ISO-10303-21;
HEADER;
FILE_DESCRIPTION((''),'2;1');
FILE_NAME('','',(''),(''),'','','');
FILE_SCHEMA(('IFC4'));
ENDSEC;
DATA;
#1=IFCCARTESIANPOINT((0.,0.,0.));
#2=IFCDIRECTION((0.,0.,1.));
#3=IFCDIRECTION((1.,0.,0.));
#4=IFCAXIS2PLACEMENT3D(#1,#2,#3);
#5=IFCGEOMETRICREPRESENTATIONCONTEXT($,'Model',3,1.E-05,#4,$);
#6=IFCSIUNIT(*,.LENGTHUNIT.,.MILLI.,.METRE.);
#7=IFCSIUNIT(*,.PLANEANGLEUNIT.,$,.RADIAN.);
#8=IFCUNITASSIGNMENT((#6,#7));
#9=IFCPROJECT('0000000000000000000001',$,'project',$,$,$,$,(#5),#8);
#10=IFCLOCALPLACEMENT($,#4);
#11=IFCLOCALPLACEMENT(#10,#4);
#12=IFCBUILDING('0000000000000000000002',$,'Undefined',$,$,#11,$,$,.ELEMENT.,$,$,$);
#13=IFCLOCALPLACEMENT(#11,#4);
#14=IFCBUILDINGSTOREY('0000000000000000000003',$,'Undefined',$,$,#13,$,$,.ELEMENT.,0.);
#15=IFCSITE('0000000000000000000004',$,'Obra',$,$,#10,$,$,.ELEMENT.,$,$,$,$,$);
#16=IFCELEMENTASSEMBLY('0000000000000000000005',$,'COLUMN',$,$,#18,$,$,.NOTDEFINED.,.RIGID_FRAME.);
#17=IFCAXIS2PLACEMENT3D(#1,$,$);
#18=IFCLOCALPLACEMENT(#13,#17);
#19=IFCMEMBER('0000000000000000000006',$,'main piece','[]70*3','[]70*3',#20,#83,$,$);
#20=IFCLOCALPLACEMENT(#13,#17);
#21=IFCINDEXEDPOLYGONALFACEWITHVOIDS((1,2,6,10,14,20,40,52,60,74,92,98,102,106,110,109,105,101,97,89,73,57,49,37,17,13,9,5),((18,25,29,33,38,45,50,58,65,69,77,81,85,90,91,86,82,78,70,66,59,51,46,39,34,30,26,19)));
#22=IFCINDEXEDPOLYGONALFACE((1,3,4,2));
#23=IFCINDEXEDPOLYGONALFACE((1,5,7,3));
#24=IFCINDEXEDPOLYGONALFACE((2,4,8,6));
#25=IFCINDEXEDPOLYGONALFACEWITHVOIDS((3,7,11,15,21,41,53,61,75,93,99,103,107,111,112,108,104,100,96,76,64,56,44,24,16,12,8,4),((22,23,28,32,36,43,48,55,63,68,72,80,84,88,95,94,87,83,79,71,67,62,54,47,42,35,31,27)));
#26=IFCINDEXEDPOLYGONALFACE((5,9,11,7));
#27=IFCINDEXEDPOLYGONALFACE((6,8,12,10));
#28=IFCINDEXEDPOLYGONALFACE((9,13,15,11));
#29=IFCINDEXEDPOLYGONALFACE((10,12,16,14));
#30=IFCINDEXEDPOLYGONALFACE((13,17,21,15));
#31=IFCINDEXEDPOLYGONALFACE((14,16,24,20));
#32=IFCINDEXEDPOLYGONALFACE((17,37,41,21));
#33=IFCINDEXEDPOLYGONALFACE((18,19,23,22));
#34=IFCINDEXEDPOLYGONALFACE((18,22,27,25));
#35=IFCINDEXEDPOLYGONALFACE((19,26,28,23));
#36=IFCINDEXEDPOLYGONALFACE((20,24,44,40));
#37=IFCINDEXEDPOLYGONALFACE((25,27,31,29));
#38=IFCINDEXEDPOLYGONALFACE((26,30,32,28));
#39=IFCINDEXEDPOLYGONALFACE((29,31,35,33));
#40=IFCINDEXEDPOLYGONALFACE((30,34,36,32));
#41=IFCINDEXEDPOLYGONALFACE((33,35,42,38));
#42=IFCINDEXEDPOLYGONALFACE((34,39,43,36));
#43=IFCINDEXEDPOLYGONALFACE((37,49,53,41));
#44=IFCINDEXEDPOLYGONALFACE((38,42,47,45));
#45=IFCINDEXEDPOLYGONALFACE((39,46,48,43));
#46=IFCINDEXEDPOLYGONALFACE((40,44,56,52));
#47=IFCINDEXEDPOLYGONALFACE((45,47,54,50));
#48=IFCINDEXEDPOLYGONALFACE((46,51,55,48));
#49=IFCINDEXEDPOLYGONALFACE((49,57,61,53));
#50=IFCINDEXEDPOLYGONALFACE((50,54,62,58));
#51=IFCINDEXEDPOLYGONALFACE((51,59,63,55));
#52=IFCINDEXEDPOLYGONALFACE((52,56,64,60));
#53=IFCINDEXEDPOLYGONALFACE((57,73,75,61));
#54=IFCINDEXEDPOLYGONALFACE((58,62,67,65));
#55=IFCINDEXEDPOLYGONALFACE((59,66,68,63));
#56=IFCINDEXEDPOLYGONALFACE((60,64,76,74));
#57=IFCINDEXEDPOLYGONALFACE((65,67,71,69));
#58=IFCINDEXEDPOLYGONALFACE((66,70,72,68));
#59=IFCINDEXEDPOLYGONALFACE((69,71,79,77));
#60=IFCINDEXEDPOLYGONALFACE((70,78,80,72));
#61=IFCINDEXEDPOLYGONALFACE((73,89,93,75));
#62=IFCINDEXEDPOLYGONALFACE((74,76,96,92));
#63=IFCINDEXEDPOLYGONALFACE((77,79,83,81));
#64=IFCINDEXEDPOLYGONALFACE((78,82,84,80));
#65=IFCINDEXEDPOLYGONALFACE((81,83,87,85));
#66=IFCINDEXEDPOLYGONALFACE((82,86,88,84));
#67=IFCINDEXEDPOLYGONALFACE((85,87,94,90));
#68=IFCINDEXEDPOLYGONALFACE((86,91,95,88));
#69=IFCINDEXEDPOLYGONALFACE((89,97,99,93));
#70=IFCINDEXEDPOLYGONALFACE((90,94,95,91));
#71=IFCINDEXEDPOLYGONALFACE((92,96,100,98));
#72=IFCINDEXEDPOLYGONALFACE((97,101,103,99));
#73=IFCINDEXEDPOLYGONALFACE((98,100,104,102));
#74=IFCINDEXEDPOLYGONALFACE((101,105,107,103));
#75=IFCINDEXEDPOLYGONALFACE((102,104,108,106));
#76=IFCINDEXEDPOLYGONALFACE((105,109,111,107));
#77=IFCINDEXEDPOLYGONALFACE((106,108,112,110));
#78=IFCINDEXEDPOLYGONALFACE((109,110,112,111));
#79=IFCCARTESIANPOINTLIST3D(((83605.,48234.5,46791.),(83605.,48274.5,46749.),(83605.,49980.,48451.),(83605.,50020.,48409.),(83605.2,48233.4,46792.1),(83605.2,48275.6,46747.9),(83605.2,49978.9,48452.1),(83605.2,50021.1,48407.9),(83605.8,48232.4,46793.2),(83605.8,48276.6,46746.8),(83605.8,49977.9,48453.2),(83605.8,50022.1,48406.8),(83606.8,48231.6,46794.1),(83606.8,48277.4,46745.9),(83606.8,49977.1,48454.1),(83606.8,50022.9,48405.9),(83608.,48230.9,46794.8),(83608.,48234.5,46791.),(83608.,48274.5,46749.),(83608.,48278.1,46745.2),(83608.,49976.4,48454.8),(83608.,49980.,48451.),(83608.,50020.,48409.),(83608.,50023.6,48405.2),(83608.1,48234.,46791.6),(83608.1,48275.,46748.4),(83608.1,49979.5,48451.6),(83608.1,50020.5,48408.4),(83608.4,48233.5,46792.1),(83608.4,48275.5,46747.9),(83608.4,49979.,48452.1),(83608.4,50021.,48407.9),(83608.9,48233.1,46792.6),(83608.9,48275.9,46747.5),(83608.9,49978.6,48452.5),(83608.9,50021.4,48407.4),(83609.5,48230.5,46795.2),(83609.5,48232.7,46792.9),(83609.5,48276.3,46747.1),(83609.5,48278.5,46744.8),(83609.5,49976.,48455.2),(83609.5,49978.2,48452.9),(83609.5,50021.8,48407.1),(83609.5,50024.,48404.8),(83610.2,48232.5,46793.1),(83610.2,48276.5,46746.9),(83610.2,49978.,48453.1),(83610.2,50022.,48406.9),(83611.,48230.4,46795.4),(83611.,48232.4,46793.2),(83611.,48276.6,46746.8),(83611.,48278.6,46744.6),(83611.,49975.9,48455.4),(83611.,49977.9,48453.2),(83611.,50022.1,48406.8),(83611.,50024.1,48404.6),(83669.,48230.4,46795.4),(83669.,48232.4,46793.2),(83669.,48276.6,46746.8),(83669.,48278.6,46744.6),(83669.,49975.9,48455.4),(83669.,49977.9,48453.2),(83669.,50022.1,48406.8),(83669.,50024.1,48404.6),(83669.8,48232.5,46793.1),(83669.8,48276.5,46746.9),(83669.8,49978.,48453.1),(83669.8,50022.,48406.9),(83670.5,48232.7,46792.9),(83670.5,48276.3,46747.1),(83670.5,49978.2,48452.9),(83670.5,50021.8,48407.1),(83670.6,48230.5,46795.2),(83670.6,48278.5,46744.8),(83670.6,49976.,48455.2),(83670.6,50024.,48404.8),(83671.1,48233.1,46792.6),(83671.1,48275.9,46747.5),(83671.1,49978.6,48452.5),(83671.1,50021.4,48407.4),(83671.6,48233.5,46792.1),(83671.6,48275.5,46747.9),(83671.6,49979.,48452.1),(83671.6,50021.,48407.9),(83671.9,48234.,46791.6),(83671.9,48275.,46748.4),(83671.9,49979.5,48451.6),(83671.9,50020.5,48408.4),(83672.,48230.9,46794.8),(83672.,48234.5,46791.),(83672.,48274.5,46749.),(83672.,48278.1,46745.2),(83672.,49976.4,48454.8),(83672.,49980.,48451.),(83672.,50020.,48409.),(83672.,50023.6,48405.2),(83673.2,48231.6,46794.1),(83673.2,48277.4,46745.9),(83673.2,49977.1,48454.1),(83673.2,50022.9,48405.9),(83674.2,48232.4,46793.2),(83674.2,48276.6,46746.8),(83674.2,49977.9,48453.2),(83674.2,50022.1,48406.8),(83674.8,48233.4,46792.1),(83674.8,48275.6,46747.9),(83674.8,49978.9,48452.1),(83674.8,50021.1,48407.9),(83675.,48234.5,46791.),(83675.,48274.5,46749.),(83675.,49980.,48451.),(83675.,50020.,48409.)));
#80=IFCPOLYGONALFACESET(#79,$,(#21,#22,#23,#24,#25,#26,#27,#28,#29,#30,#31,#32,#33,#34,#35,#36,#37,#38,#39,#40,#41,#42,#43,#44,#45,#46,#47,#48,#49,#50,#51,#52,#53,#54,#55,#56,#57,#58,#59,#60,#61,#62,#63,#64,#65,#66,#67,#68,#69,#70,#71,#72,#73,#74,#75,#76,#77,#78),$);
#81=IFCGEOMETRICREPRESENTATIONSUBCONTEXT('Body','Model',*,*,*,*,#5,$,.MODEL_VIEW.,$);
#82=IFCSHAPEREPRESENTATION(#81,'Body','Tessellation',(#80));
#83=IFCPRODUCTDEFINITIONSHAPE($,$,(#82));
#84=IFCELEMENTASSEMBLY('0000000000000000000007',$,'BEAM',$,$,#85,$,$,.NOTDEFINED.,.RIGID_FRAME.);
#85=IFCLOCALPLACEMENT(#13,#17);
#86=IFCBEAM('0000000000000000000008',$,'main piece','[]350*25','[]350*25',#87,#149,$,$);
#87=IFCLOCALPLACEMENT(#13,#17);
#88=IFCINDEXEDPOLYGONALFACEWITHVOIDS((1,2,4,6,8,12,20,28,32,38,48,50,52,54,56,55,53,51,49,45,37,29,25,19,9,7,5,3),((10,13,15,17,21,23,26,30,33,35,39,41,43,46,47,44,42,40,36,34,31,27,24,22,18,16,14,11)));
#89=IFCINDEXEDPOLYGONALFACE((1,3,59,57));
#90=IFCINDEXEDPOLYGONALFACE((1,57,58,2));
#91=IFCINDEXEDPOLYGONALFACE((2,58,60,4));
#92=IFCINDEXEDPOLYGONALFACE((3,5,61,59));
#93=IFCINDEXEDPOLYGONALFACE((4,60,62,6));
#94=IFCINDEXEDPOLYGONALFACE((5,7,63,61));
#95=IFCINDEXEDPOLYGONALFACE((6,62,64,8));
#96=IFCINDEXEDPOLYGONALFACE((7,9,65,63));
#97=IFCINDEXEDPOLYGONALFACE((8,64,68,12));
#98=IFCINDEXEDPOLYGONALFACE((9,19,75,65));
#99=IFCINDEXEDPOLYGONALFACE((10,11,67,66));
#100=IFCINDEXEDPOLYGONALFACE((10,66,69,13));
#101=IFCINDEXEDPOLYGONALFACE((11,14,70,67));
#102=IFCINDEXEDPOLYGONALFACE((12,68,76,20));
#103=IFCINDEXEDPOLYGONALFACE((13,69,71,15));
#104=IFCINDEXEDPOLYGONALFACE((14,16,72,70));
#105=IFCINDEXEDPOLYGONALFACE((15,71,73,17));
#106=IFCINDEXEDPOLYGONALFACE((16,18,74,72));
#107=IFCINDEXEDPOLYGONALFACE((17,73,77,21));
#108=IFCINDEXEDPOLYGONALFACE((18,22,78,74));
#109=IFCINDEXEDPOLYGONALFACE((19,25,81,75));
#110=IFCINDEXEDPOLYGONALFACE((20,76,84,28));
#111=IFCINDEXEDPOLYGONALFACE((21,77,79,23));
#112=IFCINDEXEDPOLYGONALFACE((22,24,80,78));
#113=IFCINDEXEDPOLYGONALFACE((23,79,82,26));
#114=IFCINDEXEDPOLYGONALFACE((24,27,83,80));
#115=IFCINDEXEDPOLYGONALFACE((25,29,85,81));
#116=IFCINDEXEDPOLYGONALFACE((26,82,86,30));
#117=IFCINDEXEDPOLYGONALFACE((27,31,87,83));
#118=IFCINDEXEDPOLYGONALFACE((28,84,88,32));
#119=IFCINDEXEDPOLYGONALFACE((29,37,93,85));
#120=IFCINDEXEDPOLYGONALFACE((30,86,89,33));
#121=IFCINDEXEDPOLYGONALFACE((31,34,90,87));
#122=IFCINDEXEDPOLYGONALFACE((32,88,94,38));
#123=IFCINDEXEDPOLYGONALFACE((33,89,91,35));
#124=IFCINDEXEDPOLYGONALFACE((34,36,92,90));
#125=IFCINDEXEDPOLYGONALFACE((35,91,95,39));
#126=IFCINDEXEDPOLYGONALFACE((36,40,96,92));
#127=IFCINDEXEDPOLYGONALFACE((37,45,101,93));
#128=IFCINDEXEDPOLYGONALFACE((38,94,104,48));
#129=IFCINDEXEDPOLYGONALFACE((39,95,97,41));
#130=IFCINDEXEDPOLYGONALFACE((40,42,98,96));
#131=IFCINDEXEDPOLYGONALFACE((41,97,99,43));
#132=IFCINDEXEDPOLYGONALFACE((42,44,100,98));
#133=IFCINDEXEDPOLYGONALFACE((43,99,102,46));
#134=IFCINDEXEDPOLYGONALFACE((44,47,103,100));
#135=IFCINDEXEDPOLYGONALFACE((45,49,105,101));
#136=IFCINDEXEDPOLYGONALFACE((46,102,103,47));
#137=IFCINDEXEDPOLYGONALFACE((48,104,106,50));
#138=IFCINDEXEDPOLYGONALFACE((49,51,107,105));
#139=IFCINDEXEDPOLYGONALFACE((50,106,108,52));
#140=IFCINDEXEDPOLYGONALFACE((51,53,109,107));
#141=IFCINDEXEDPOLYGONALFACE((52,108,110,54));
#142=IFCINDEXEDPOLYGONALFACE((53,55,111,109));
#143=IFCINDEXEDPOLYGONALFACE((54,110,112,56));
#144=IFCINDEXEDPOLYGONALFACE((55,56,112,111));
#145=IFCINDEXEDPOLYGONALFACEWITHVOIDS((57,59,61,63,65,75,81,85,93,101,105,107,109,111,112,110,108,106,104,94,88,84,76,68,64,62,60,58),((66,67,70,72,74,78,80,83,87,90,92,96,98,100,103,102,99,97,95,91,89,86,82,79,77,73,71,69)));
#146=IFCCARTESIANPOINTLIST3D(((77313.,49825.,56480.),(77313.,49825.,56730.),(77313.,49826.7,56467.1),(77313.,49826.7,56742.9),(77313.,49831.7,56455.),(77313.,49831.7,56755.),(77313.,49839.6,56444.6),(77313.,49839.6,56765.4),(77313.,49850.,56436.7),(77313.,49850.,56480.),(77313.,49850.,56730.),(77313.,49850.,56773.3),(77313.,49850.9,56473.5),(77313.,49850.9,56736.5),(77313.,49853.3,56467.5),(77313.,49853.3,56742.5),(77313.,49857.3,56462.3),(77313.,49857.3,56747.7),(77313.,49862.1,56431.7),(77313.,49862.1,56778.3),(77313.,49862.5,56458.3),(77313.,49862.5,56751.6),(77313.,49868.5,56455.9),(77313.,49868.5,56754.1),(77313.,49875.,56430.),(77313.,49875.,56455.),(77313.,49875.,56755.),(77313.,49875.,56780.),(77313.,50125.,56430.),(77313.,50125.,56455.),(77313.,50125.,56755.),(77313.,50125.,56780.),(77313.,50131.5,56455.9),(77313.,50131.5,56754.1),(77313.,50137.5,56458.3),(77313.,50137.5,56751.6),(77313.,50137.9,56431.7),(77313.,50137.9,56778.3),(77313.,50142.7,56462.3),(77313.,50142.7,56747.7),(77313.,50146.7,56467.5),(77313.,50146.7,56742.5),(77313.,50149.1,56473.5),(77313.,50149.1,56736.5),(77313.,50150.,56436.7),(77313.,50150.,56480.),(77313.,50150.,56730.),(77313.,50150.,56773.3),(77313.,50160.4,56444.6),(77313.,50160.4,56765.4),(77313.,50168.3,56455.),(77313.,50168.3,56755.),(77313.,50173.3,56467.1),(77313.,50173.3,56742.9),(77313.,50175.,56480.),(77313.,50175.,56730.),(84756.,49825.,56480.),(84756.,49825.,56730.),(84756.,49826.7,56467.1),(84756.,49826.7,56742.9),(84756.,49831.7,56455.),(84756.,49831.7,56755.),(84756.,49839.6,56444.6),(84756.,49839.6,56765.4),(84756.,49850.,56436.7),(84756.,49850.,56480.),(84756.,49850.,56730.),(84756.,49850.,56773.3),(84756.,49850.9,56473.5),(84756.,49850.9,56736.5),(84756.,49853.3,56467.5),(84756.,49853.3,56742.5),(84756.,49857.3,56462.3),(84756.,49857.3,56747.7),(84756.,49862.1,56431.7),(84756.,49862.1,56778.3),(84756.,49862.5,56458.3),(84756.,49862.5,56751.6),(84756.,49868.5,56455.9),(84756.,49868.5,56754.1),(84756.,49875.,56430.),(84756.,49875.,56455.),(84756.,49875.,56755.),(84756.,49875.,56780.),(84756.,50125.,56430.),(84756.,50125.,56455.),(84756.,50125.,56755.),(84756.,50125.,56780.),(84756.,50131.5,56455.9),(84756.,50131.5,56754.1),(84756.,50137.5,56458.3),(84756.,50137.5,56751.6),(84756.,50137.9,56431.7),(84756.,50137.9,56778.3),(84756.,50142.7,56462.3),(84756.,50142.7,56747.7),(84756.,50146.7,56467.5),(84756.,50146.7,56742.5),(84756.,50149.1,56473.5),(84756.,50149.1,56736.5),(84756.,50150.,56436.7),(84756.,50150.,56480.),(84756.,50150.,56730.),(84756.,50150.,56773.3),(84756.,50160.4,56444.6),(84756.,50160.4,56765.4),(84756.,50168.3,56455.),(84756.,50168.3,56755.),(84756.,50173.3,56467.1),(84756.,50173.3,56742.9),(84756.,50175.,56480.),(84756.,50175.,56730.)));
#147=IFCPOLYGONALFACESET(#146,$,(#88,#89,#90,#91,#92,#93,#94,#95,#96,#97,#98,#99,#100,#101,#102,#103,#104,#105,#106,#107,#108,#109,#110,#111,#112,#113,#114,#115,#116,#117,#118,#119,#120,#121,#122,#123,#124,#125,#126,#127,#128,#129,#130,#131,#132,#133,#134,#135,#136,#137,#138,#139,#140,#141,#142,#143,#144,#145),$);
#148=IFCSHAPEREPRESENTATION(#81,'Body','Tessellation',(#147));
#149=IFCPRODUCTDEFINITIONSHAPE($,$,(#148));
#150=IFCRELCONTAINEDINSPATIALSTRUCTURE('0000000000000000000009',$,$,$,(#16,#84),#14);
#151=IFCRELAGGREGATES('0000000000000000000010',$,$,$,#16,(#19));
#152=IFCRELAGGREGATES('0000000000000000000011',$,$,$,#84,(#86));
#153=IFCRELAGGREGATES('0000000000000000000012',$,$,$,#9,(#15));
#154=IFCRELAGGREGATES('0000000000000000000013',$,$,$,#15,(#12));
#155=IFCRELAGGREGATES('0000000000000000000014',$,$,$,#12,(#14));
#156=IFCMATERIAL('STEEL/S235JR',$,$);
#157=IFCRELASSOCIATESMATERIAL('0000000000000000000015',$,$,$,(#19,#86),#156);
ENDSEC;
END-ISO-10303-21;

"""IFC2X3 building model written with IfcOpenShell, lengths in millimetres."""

from ifc_helpers import new_model, si_unit, frame, origin_with_axes, origin_2d_with_axis, place, context, subcontext, project, spatial, hollow_rectangle, extrude, material, element, aggregate, save


model = new_model("IFC2X3")

# Units and contexts
model_context = context("Model", 3, precision=1e-05, world=origin_with_axes())
body_context = subcontext(model_context, "Body", "Model", "MODEL_VIEW")
ifc_project = project(units=[si_unit("LENGTHUNIT", "METRE", prefix="MILLI"), si_unit("PLANEANGLEUNIT", "RADIAN")], contexts=[model_context])

# Site, building, storey
site_placement = place(None, origin_with_axes())
site = spatial("IfcSite", under=ifc_project, at=site_placement, Name="Obra", CompositionType="ELEMENT")
building_placement = place(site_placement, origin_with_axes())
building = spatial("IfcBuilding", under=site, at=building_placement, Name="Undefined", CompositionType="ELEMENT")
storey_placement = place(building_placement, origin_with_axes())
storey = spatial("IfcBuildingStorey", under=building, at=storey_placement, Name="Undefined", CompositionType="ELEMENT", Elevation=0.0)

# Shared definitions
ifc_material = material(Name="STEEL/S235JR")

# Element assembly, member
assembly_1_placement = place(storey_placement, origin_with_axes())
assembly_1 = element("IfcElementAssembly", 1, at=assembly_1_placement, inside=storey, Name="COLUMN", AssemblyPlace="NOTDEFINED", PredefinedType="RIGID_FRAME")
member_1_placement = place(assembly_1_placement, frame((83640.0, 48254.5, 46770.0), z_axis=(-1.0, 0.0, 0.0), x_axis=(0.0, 0.724633, 0.689135)))
member_1 = element("IfcMember", 2, at=member_1_placement, material=ifc_material, Name="main piece", Description="[]70*3", ObjectType="[]70*3", context=body_context, shape_type="SweptSolid", body=[
    extrude(hollow_rectangle(XDim=70.0, YDim=70.0, WallThickness=3.0, InnerFilletRadius=3.0, OuterFilletRadius=6.0, at=origin_2d_with_axis()), frame((2408.8, 0.0, 0.0), z_axis=(-1.0, 0.0, 0.0), x_axis=(0.0, -1.0, 0.0)), (0.0, 0.0, 1.0), 2408.8),
])
aggregate(assembly_1, [member_1])

# Element assembly, beam
assembly_2_placement = place(storey_placement, origin_with_axes())
assembly_2 = element("IfcElementAssembly", 3, at=assembly_2_placement, inside=storey, Name="BEAM", AssemblyPlace="NOTDEFINED", PredefinedType="RIGID_FRAME")
beam_1_placement = place(assembly_2_placement, frame((84756.0, 50000.0, 56605.0), z_axis=(0.0, 0.0, 1.0), x_axis=(-1.0, 0.0, 0.0)))
beam_1 = element("IfcBeam", 4, at=beam_1_placement, material=ifc_material, Name="main piece", Description="[]350*25", ObjectType="[]350*25", context=body_context, shape_type="SweptSolid", body=[
    extrude(hollow_rectangle(XDim=350.0, YDim=350.0, WallThickness=25.0, InnerFilletRadius=25.0, OuterFilletRadius=50.0, at=origin_2d_with_axis()), frame((7443.0, 0.0, 0.0), z_axis=(-1.0, 0.0, 0.0), x_axis=(0.0, -1.0, 0.0)), (0.0, 0.0, 1.0), 7443.0),
])
aggregate(assembly_2, [beam_1])

save(model, "model.ifc")
